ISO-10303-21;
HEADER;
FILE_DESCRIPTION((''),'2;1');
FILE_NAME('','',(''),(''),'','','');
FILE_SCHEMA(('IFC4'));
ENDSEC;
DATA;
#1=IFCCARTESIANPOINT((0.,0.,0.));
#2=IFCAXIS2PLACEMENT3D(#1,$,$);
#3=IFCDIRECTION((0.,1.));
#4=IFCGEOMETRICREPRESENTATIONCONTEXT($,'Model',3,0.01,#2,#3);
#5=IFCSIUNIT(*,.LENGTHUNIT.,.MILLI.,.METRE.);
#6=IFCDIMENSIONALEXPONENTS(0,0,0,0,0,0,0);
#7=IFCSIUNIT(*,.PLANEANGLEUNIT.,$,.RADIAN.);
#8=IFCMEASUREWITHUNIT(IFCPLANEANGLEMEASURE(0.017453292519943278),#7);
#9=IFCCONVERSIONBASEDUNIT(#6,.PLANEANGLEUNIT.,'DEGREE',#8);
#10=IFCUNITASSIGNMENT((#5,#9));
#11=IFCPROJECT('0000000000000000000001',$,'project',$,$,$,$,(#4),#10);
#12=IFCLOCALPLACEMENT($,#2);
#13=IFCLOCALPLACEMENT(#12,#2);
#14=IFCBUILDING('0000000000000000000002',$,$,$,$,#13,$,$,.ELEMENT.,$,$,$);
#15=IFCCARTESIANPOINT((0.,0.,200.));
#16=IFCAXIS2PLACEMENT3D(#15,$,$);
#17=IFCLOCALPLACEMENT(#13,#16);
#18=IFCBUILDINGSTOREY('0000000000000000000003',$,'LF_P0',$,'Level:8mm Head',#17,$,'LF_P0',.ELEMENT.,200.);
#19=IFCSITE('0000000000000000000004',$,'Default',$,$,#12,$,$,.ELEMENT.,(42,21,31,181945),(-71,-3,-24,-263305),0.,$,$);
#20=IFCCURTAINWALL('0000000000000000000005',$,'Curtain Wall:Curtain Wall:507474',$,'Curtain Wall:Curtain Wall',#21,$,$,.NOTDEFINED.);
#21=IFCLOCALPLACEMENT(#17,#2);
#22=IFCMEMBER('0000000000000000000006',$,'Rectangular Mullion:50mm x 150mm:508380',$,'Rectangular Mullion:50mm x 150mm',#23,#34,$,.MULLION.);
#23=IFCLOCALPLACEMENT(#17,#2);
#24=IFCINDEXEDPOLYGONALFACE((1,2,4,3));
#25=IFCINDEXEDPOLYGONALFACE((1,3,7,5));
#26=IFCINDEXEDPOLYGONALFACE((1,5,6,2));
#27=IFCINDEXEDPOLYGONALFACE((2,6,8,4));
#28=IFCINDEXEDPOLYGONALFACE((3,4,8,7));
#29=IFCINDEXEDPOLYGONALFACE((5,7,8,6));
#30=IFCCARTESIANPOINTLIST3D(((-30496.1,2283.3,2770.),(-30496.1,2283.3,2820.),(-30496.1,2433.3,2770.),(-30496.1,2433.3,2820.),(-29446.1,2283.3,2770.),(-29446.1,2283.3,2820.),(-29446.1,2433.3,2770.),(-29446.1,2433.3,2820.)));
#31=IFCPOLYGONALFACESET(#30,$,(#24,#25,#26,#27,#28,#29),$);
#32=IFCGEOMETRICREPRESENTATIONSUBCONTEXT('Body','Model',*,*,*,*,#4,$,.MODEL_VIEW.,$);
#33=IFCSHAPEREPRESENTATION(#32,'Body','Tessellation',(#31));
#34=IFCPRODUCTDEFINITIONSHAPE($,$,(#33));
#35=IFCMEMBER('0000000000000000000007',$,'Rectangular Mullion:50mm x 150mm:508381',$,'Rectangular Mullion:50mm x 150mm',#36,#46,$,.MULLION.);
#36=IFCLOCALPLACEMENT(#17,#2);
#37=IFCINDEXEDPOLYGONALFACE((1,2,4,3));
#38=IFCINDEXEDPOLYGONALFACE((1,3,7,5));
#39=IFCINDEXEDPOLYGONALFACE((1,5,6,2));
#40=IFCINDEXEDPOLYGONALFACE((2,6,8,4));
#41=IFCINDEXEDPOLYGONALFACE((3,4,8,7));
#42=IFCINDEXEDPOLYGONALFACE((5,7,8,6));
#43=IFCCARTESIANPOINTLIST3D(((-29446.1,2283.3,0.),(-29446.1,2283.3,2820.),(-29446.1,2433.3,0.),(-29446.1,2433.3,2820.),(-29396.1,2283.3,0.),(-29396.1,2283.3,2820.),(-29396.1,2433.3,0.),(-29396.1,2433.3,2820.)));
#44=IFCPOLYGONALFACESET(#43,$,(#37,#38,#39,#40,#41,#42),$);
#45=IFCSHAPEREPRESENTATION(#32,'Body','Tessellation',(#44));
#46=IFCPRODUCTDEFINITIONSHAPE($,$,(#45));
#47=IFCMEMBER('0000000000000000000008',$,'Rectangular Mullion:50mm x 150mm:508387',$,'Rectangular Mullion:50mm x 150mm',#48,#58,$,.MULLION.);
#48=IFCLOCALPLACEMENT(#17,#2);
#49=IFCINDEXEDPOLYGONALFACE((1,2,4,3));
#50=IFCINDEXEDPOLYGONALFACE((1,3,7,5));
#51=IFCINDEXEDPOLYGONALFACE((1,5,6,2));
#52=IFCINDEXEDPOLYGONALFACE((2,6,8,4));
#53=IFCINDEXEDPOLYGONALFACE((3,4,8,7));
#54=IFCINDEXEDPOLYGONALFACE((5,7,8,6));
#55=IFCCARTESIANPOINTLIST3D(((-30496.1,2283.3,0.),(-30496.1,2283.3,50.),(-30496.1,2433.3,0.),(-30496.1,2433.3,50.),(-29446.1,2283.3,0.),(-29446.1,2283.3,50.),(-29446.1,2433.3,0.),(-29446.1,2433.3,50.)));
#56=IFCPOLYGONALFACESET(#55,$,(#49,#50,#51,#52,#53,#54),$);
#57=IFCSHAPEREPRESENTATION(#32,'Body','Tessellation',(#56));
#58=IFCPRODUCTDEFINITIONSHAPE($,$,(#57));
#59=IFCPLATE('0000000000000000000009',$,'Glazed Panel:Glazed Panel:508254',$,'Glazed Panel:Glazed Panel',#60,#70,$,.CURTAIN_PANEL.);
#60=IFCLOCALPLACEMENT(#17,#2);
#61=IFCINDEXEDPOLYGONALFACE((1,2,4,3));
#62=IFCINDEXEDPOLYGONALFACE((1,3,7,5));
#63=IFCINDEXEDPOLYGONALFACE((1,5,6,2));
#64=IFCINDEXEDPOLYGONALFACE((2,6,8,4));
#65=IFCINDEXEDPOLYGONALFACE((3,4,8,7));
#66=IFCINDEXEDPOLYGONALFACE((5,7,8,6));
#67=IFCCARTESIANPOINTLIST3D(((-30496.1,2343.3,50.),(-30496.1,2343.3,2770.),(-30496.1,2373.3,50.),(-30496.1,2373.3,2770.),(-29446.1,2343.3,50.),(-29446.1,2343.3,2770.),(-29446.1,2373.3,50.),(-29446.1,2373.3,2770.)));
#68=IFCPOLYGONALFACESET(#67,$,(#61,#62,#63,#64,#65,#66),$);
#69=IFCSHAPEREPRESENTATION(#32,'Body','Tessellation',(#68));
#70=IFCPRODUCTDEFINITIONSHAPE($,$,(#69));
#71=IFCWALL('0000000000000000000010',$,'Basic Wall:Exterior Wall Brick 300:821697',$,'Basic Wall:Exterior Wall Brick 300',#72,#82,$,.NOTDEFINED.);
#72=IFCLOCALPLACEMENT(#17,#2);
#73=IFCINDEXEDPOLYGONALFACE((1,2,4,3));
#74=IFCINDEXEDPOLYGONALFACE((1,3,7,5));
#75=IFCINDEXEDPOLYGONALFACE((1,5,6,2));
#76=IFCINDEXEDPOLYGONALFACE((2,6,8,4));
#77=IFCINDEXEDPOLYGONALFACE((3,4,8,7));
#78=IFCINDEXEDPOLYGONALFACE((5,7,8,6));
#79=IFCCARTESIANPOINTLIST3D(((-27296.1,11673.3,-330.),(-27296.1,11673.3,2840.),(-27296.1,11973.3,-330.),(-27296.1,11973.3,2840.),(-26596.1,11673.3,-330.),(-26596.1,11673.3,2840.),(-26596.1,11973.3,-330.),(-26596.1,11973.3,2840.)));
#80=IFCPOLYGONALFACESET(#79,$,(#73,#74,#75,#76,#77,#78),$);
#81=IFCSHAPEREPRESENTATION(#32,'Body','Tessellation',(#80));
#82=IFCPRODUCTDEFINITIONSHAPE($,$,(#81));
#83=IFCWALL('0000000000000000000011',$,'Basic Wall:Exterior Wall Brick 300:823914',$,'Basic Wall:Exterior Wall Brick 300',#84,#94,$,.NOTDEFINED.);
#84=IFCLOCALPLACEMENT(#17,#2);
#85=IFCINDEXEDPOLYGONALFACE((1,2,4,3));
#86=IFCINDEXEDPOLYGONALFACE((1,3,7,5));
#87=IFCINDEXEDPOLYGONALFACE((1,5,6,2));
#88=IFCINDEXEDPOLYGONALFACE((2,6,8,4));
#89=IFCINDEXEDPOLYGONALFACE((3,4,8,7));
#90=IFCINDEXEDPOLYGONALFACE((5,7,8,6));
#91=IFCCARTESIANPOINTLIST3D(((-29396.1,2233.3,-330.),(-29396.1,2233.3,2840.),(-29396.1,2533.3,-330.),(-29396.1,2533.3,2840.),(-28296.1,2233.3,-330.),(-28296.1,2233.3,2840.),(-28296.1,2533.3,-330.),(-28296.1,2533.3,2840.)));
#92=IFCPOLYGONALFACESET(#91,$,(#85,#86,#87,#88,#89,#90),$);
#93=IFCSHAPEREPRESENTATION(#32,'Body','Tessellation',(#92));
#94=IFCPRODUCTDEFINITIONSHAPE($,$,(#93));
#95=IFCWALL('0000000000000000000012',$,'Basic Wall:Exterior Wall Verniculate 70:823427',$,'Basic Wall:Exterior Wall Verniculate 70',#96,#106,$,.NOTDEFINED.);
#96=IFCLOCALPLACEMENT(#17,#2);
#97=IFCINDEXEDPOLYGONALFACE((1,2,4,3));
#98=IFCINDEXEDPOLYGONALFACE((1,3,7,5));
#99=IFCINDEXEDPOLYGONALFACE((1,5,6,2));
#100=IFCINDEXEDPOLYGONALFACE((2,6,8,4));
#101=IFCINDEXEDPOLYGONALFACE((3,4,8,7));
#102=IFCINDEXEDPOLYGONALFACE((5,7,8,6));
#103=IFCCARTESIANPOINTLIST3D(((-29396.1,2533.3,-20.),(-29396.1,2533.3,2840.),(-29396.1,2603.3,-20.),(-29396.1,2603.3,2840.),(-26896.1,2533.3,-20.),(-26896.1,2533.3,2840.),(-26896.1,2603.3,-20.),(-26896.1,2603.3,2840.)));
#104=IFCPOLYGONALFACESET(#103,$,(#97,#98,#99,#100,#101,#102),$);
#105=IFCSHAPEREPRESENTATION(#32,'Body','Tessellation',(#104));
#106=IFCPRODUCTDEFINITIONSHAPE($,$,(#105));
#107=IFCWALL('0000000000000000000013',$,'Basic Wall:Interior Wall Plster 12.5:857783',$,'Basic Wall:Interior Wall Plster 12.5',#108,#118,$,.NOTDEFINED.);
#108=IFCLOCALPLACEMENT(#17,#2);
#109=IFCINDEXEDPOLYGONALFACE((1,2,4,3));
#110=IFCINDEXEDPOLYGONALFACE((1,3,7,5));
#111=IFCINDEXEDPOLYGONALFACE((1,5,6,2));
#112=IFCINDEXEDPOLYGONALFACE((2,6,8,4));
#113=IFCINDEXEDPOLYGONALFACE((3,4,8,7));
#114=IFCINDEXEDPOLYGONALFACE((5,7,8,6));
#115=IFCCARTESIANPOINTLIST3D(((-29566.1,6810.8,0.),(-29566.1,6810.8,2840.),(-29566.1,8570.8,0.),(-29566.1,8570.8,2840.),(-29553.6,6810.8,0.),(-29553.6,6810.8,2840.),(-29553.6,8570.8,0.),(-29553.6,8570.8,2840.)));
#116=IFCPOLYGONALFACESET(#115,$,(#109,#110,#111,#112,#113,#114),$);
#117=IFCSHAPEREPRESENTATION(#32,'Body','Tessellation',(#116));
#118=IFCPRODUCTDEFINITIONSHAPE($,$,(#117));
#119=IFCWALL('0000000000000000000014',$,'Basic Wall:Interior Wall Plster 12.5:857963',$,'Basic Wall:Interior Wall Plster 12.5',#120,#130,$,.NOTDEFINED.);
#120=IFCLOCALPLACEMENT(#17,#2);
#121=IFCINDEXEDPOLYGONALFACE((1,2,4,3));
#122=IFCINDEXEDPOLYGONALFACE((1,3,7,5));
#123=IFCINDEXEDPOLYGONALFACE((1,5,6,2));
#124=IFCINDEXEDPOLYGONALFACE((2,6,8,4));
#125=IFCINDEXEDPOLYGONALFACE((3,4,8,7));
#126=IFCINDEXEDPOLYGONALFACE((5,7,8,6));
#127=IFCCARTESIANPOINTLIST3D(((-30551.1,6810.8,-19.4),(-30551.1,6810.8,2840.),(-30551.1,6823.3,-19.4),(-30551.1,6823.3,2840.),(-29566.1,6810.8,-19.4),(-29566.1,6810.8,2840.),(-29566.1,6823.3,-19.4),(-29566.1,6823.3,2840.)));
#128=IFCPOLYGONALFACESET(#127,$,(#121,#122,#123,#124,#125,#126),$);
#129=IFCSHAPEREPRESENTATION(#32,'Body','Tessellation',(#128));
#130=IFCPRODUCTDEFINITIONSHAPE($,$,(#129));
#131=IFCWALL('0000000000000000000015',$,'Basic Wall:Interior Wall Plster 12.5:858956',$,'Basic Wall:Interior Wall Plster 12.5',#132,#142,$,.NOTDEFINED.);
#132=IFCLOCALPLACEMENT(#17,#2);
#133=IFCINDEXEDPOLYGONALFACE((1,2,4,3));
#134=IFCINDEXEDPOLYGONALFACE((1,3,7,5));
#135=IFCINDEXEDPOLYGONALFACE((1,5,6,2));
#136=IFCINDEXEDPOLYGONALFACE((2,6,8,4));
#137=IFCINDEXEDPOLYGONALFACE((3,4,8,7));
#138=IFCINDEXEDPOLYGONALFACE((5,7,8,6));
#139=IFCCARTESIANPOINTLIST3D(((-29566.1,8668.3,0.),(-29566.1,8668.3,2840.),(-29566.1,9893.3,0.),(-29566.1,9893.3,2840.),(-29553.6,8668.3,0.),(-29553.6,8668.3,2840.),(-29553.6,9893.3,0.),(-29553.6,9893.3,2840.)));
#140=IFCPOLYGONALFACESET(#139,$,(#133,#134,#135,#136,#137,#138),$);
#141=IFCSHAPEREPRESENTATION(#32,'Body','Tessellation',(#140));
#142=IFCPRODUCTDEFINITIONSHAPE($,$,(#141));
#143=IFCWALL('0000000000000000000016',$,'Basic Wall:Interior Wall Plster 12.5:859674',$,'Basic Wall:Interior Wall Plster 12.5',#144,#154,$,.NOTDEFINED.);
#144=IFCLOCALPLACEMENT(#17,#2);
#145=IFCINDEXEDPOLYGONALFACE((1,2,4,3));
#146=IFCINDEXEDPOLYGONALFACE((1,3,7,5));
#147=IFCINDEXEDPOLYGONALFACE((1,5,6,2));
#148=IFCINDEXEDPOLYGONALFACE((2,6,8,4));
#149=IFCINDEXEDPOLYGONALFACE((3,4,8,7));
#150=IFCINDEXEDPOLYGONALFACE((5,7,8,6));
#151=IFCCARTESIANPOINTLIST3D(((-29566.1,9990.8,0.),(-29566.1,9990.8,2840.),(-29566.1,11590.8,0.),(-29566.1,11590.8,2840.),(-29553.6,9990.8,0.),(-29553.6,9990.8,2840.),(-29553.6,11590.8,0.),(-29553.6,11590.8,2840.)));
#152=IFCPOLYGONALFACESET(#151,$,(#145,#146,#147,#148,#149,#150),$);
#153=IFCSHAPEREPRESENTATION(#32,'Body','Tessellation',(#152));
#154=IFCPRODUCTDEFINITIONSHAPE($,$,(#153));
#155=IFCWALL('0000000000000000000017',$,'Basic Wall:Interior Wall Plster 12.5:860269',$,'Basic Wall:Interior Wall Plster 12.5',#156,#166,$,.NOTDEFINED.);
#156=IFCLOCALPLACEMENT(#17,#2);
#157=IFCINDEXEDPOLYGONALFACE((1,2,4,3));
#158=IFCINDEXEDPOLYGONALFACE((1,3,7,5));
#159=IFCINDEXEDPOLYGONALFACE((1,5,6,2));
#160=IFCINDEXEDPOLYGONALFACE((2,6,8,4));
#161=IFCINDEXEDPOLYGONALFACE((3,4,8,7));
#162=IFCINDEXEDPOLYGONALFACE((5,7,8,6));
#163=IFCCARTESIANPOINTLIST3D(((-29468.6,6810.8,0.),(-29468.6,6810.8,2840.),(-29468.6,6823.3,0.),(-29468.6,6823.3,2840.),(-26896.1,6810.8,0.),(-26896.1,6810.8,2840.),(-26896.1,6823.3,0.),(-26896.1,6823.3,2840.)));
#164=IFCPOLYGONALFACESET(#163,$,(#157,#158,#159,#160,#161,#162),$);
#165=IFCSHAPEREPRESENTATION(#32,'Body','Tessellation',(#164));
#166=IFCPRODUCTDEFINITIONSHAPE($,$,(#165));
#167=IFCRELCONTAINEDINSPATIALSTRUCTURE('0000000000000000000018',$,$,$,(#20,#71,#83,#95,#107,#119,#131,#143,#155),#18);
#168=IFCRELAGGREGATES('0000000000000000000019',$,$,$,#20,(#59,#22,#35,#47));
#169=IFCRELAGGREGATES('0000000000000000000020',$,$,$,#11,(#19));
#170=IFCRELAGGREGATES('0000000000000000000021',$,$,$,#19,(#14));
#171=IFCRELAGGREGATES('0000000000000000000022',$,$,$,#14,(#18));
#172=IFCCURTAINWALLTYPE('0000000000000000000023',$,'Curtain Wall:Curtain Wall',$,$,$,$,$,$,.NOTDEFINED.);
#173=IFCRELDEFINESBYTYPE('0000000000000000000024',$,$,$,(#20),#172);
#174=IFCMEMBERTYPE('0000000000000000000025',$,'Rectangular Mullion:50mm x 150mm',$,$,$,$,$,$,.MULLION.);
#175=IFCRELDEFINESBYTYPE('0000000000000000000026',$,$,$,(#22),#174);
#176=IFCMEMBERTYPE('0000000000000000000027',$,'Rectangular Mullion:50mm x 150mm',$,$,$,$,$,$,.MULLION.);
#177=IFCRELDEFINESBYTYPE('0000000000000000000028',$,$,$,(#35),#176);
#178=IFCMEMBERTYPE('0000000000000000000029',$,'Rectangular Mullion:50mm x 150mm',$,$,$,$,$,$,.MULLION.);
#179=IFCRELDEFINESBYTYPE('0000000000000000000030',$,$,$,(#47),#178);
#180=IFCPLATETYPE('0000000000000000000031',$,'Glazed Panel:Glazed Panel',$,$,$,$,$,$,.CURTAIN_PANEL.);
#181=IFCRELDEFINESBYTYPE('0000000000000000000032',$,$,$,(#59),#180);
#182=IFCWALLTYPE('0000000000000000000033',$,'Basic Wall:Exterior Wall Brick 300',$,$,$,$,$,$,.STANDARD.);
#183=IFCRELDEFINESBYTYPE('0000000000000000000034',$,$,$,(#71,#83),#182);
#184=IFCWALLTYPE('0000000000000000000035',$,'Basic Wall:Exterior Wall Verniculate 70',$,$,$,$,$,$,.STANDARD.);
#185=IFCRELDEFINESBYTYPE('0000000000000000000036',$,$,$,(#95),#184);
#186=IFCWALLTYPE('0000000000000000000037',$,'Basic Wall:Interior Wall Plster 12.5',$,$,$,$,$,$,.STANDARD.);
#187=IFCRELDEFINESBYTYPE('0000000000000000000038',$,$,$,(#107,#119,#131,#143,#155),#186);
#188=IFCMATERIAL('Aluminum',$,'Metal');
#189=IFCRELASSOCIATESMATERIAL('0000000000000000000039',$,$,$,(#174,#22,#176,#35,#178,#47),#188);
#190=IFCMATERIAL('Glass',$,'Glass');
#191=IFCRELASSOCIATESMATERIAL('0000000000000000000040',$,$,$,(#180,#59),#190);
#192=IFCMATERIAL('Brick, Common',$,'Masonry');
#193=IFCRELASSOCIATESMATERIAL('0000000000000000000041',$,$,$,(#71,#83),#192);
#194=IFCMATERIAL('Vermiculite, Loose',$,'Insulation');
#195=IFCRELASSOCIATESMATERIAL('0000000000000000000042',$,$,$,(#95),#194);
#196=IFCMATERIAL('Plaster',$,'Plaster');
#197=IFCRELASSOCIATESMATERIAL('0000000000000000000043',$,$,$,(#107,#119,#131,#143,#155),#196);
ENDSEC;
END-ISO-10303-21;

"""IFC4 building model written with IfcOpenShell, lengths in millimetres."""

from ifc_helpers import new_model, entity, si_unit, converted_unit, direction, frame, origin, place, context, subcontext, project, spatial, indexed_curve, outline, extrude, source, transform, mapped, material, type_object, type_shapes, element, aggregate, save


model = new_model("IFC4")

# Units and contexts
model_context = context("Model", 3, precision=0.01, world=origin(), true_north=direction((0.0, 1.0)))
body_context = subcontext(model_context, "Body", "Model", "MODEL_VIEW")
ifc_project = project(units=[si_unit("LENGTHUNIT", "METRE", prefix="MILLI"), converted_unit("PLANEANGLEUNIT", "DEGREE", entity("IfcPlaneAngleMeasure", 0.017453292519943278), si_unit("PLANEANGLEUNIT", "RADIAN"), dimensions=[0, 0, 0, 0, 0, 0, 0])], contexts=[model_context])

# Site, building, storey
site_placement = place(None, origin())
site = spatial("IfcSite", under=ifc_project, at=site_placement, Name="Default", CompositionType="ELEMENT", RefLatitude=(42, 21, 31, 181945), RefLongitude=(-71, -3, -24, -263305), RefElevation=0.0)
building_placement = place(site_placement, origin())
building = spatial("IfcBuilding", under=site, at=building_placement, CompositionType="ELEMENT")
storey_placement = place(building_placement, frame((0.0, 0.0, 200.0)))
storey = spatial("IfcBuildingStorey", under=building, at=storey_placement, Name="LF_P0", ObjectType="Level:8mm Head", LongName="LF_P0", CompositionType="ELEMENT", Elevation=200.0)

# Curtain wall, members, plate
curtain_wall_type = type_object("IfcCurtainWallType", Name="Curtain Wall:Curtain Wall", PredefinedType="NOTDEFINED")
curtain_wall_placement = place(storey_placement, frame((0.0, 0.0, -200.0)))
curtain_wall = element("IfcCurtainWall", 1, at=curtain_wall_placement, inside=storey, type_object=curtain_wall_type, Name="Curtain Wall:Curtain Wall:507474", ObjectType="Curtain Wall:Curtain Wall", PredefinedType="NOTDEFINED")
ifc_material_1 = material(Name="Aluminum", Category="Metal")
member_type_1 = type_object("IfcMemberType", Name="Rectangular Mullion:50mm x 150mm", PredefinedType="MULLION", material=ifc_material_1)
shared_shape_1 = source(origin(), body_context, "Body", "SweptSolid", [
    extrude(outline(indexed_curve([(-25.0, -75.0), (25.0, -75.0), (25.0, 75.0), (-25.0, 75.0), (-25.0, -75.0)], self_intersect=False)), frame((-25.0, 0.0, -1050.0), z_axis=(0.0, 0.0, 1.0), x_axis=(-1.0, 0.0, 0.0)), (0.0, 0.0, 1.0), 1050.0),
])
type_shapes(member_type_1, [shared_shape_1])
member_1_placement = place(curtain_wall_placement, frame((-29446.1, 2358.3, 3020.0), z_axis=(1.0, 0.0, 0.0), x_axis=(0.0, 0.0, 1.0)))
member_1 = element("IfcMember", 2, at=member_1_placement, type_object=member_type_1, material=ifc_material_1, Name="Rectangular Mullion:50mm x 150mm:508380", ObjectType="Rectangular Mullion:50mm x 150mm", PredefinedType="MULLION", context=body_context, shape_type="MappedRepresentation", body=[
    mapped(shared_shape_1, transform((0.0, 0.0, 0.0), scale=1.0)),
])
member_type_2 = type_object("IfcMemberType", Name="Rectangular Mullion:50mm x 150mm", PredefinedType="MULLION", material=ifc_material_1)
shared_shape_2 = source(origin(), body_context, "Body", "SweptSolid", [
    extrude(outline(indexed_curve([(-25.0, -75.0), (25.0, -75.0), (25.0, 75.0), (-25.0, 75.0), (-25.0, -75.0)], self_intersect=False)), frame((-25.0, 0.0, -2820.0), z_axis=(0.0, 0.0, 1.0), x_axis=(-1.0, 0.0, 0.0)), (0.0, 0.0, 1.0), 2820.0),
])
type_shapes(member_type_2, [shared_shape_2])
member_2_placement = place(curtain_wall_placement, frame((-29396.1, 2358.3, 200.0), z_axis=(0.0, 0.0, -1.0), x_axis=(1.0, 0.0, 0.0)))
member_2 = element("IfcMember", 3, at=member_2_placement, type_object=member_type_2, material=ifc_material_1, Name="Rectangular Mullion:50mm x 150mm:508381", ObjectType="Rectangular Mullion:50mm x 150mm", PredefinedType="MULLION", context=body_context, shape_type="MappedRepresentation", body=[
    mapped(shared_shape_2, transform((0.0, 0.0, 0.0), scale=1.0)),
])
member_type_3 = type_object("IfcMemberType", Name="Rectangular Mullion:50mm x 150mm", PredefinedType="MULLION", material=ifc_material_1)
shared_shape_3 = source(origin(), body_context, "Body", "SweptSolid", [
    extrude(outline(indexed_curve([(-25.0, -75.0), (25.0, -75.0), (25.0, 75.0), (-25.0, 75.0), (-25.0, -75.0)], self_intersect=False)), frame((-25.0, 0.0, -1050.0), z_axis=(0.0, 0.0, 1.0), x_axis=(-1.0, 0.0, 0.0)), (0.0, 0.0, 1.0), 1050.0),
])
type_shapes(member_type_3, [shared_shape_3])
member_3_placement = place(curtain_wall_placement, frame((-30496.1, 2358.3, 200.0), z_axis=(-1.0, 0.0, 0.0), x_axis=(0.0, 0.0, -1.0)))
member_3 = element("IfcMember", 4, at=member_3_placement, type_object=member_type_3, material=ifc_material_1, Name="Rectangular Mullion:50mm x 150mm:508387", ObjectType="Rectangular Mullion:50mm x 150mm", PredefinedType="MULLION", context=body_context, shape_type="MappedRepresentation", body=[
    mapped(shared_shape_3, transform((0.0, 0.0, 0.0), scale=1.0)),
])
ifc_material_2 = material(Name="Glass", Category="Glass")
plate_type = type_object("IfcPlateType", Name="Glazed Panel:Glazed Panel", PredefinedType="CURTAIN_PANEL", material=ifc_material_2)
shared_shape_4 = source(origin(), body_context, "Body", "SweptSolid", [
    extrude(outline(indexed_curve([(-15.0, -525.0), (15.0, -525.0), (15.0, 525.0), (-15.0, 525.0), (-15.0, -525.0)], self_intersect=False)), frame((0.0, 0.0, 0.0), z_axis=(0.0, 0.0, 1.0), x_axis=(0.0, 1.0, 0.0)), (0.0, 0.0, 1.0), 2720.0),
])
type_shapes(plate_type, [shared_shape_4])
plate_placement = place(curtain_wall_placement, frame((-29971.1, 2358.3, 250.0)))
plate = element("IfcPlate", 5, at=plate_placement, type_object=plate_type, material=ifc_material_2, Name="Glazed Panel:Glazed Panel:508254", ObjectType="Glazed Panel:Glazed Panel", PredefinedType="CURTAIN_PANEL", context=body_context, shape_type="MappedRepresentation", body=[
    mapped(shared_shape_4, transform((0.0, 0.0, 0.0), scale=1.0)),
])
aggregate(curtain_wall, [plate, member_1, member_2, member_3])

# Walls
ifc_material_3 = material(Name="Brick, Common", Category="Masonry")
wall_type_1 = type_object("IfcWallType", Name="Basic Wall:Exterior Wall Brick 300", PredefinedType="STANDARD")
wall_1_placement = place(storey_placement, frame((-27296.1, 11823.3, -330.0)))
element("IfcWall", 6, at=wall_1_placement, inside=storey, type_object=wall_type_1, material=ifc_material_3, Name="Basic Wall:Exterior Wall Brick 300:821697", ObjectType="Basic Wall:Exterior Wall Brick 300", PredefinedType="NOTDEFINED", context=body_context, shape_type="SweptSolid", body=[
    extrude(outline(indexed_curve([(700.0, 150.0), (0.0, 150.0), (0.0, -150.0), (700.0, -150.0), (700.0, 150.0)], self_intersect=False)), origin(), (0.0, 0.0, 1.0), 3170.0),
])
wall_2_placement = place(storey_placement, frame((-28296.1, 2383.3, -330.0), z_axis=(0.0, 0.0, 1.0), x_axis=(-1.0, 0.0, 0.0)))
element("IfcWall", 7, at=wall_2_placement, inside=storey, type_object=wall_type_1, material=ifc_material_3, Name="Basic Wall:Exterior Wall Brick 300:823914", ObjectType="Basic Wall:Exterior Wall Brick 300", PredefinedType="NOTDEFINED", context=body_context, shape_type="SweptSolid", body=[
    extrude(outline(indexed_curve([(1100.0, 150.0), (0.0, 150.0), (0.0, -150.0), (1100.0, -150.0), (1100.0, 150.0)], self_intersect=False)), origin(), (0.0, 0.0, 1.0), 3170.0),
])
ifc_material_4 = material(Name="Vermiculite, Loose", Category="Insulation")
wall_type_2 = type_object("IfcWallType", Name="Basic Wall:Exterior Wall Verniculate 70", PredefinedType="STANDARD")
wall_3_placement = place(storey_placement, frame((-26896.1, 2568.3, -20.0), z_axis=(0.0, 0.0, 1.0), x_axis=(-1.0, 0.0, 0.0)))
element("IfcWall", 8, at=wall_3_placement, inside=storey, type_object=wall_type_2, material=ifc_material_4, Name="Basic Wall:Exterior Wall Verniculate 70:823427", ObjectType="Basic Wall:Exterior Wall Verniculate 70", PredefinedType="NOTDEFINED", context=body_context, shape_type="SweptSolid", body=[
    extrude(outline(indexed_curve([(2500.0, 35.0), (0.0, 35.0), (0.0, -35.0), (2500.0, -35.0), (2500.0, 35.0)], self_intersect=False)), origin(), (0.0, 0.0, 1.0), 2860.0),
])
ifc_material_5 = material(Name="Plaster", Category="Plaster")
wall_type_3 = type_object("IfcWallType", Name="Basic Wall:Interior Wall Plster 12.5", PredefinedType="STANDARD")
wall_4_placement = place(storey_placement, frame((-29559.9, 8570.8, 0.0), z_axis=(0.0, 0.0, 1.0), x_axis=(0.0, -1.0, 0.0)))
element("IfcWall", 9, at=wall_4_placement, inside=storey, type_object=wall_type_3, material=ifc_material_5, Name="Basic Wall:Interior Wall Plster 12.5:857783", ObjectType="Basic Wall:Interior Wall Plster 12.5", PredefinedType="NOTDEFINED", context=body_context, shape_type="SweptSolid", body=[
    extrude(outline(indexed_curve([(1760.0, 6.2), (0.0, 6.2), (0.0, -6.2), (1760.0, -6.2), (1760.0, 6.2)], self_intersect=False)), origin(), (0.0, 0.0, 1.0), 2840.0),
])
wall_5_placement = place(storey_placement, frame((-29566.1, 6817.1, -19.4), z_axis=(0.0, 0.0, 1.0), x_axis=(-1.0, 0.0, 0.0)))
element("IfcWall", 10, at=wall_5_placement, inside=storey, type_object=wall_type_3, material=ifc_material_5, Name="Basic Wall:Interior Wall Plster 12.5:857963", ObjectType="Basic Wall:Interior Wall Plster 12.5", PredefinedType="NOTDEFINED", context=body_context, shape_type="SweptSolid", body=[
    extrude(outline(indexed_curve([(985.0, 6.2), (0.0, 6.2), (0.0, -6.2), (985.0, -6.2), (985.0, 6.2)], self_intersect=False)), origin(), (0.0, 0.0, 1.0), 2859.4),
])
wall_6_placement = place(storey_placement, frame((-29559.9, 8668.3, 0.0), z_axis=(0.0, 0.0, 1.0), x_axis=(0.0, 1.0, 0.0)))
element("IfcWall", 11, at=wall_6_placement, inside=storey, type_object=wall_type_3, material=ifc_material_5, Name="Basic Wall:Interior Wall Plster 12.5:858956", ObjectType="Basic Wall:Interior Wall Plster 12.5", PredefinedType="NOTDEFINED", context=body_context, shape_type="SweptSolid", body=[
    extrude(outline(indexed_curve([(1225.0, 6.2), (0.0, 6.2), (0.0, -6.2), (1225.0, -6.2), (1225.0, 6.2)], self_intersect=False)), origin(), (0.0, 0.0, 1.0), 2840.0),
])
wall_7_placement = place(storey_placement, frame((-29559.9, 9990.8, 0.0), z_axis=(0.0, 0.0, 1.0), x_axis=(0.0, 1.0, 0.0)))
element("IfcWall", 12, at=wall_7_placement, inside=storey, type_object=wall_type_3, material=ifc_material_5, Name="Basic Wall:Interior Wall Plster 12.5:859674", ObjectType="Basic Wall:Interior Wall Plster 12.5", PredefinedType="NOTDEFINED", context=body_context, shape_type="SweptSolid", body=[
    extrude(outline(indexed_curve([(1600.0, 6.2), (0.0, 6.2), (0.0, -6.2), (1600.0, -6.2), (1600.0, 6.2)], self_intersect=False)), origin(), (0.0, 0.0, 1.0), 2840.0),
])
wall_8_placement = place(storey_placement, frame((-29468.6, 6817.1, 0.0)))
element("IfcWall", 13, at=wall_8_placement, inside=storey, type_object=wall_type_3, material=ifc_material_5, Name="Basic Wall:Interior Wall Plster 12.5:860269", ObjectType="Basic Wall:Interior Wall Plster 12.5", PredefinedType="NOTDEFINED", context=body_context, shape_type="SweptSolid", body=[
    extrude(outline(indexed_curve([(2572.5, 6.2), (0.0, 6.2), (0.0, -6.2), (2572.5, -6.2), (2572.5, 6.2)], self_intersect=False)), origin(), (0.0, 0.0, 1.0), 2840.0),
])

save(model, "model.ifc")
